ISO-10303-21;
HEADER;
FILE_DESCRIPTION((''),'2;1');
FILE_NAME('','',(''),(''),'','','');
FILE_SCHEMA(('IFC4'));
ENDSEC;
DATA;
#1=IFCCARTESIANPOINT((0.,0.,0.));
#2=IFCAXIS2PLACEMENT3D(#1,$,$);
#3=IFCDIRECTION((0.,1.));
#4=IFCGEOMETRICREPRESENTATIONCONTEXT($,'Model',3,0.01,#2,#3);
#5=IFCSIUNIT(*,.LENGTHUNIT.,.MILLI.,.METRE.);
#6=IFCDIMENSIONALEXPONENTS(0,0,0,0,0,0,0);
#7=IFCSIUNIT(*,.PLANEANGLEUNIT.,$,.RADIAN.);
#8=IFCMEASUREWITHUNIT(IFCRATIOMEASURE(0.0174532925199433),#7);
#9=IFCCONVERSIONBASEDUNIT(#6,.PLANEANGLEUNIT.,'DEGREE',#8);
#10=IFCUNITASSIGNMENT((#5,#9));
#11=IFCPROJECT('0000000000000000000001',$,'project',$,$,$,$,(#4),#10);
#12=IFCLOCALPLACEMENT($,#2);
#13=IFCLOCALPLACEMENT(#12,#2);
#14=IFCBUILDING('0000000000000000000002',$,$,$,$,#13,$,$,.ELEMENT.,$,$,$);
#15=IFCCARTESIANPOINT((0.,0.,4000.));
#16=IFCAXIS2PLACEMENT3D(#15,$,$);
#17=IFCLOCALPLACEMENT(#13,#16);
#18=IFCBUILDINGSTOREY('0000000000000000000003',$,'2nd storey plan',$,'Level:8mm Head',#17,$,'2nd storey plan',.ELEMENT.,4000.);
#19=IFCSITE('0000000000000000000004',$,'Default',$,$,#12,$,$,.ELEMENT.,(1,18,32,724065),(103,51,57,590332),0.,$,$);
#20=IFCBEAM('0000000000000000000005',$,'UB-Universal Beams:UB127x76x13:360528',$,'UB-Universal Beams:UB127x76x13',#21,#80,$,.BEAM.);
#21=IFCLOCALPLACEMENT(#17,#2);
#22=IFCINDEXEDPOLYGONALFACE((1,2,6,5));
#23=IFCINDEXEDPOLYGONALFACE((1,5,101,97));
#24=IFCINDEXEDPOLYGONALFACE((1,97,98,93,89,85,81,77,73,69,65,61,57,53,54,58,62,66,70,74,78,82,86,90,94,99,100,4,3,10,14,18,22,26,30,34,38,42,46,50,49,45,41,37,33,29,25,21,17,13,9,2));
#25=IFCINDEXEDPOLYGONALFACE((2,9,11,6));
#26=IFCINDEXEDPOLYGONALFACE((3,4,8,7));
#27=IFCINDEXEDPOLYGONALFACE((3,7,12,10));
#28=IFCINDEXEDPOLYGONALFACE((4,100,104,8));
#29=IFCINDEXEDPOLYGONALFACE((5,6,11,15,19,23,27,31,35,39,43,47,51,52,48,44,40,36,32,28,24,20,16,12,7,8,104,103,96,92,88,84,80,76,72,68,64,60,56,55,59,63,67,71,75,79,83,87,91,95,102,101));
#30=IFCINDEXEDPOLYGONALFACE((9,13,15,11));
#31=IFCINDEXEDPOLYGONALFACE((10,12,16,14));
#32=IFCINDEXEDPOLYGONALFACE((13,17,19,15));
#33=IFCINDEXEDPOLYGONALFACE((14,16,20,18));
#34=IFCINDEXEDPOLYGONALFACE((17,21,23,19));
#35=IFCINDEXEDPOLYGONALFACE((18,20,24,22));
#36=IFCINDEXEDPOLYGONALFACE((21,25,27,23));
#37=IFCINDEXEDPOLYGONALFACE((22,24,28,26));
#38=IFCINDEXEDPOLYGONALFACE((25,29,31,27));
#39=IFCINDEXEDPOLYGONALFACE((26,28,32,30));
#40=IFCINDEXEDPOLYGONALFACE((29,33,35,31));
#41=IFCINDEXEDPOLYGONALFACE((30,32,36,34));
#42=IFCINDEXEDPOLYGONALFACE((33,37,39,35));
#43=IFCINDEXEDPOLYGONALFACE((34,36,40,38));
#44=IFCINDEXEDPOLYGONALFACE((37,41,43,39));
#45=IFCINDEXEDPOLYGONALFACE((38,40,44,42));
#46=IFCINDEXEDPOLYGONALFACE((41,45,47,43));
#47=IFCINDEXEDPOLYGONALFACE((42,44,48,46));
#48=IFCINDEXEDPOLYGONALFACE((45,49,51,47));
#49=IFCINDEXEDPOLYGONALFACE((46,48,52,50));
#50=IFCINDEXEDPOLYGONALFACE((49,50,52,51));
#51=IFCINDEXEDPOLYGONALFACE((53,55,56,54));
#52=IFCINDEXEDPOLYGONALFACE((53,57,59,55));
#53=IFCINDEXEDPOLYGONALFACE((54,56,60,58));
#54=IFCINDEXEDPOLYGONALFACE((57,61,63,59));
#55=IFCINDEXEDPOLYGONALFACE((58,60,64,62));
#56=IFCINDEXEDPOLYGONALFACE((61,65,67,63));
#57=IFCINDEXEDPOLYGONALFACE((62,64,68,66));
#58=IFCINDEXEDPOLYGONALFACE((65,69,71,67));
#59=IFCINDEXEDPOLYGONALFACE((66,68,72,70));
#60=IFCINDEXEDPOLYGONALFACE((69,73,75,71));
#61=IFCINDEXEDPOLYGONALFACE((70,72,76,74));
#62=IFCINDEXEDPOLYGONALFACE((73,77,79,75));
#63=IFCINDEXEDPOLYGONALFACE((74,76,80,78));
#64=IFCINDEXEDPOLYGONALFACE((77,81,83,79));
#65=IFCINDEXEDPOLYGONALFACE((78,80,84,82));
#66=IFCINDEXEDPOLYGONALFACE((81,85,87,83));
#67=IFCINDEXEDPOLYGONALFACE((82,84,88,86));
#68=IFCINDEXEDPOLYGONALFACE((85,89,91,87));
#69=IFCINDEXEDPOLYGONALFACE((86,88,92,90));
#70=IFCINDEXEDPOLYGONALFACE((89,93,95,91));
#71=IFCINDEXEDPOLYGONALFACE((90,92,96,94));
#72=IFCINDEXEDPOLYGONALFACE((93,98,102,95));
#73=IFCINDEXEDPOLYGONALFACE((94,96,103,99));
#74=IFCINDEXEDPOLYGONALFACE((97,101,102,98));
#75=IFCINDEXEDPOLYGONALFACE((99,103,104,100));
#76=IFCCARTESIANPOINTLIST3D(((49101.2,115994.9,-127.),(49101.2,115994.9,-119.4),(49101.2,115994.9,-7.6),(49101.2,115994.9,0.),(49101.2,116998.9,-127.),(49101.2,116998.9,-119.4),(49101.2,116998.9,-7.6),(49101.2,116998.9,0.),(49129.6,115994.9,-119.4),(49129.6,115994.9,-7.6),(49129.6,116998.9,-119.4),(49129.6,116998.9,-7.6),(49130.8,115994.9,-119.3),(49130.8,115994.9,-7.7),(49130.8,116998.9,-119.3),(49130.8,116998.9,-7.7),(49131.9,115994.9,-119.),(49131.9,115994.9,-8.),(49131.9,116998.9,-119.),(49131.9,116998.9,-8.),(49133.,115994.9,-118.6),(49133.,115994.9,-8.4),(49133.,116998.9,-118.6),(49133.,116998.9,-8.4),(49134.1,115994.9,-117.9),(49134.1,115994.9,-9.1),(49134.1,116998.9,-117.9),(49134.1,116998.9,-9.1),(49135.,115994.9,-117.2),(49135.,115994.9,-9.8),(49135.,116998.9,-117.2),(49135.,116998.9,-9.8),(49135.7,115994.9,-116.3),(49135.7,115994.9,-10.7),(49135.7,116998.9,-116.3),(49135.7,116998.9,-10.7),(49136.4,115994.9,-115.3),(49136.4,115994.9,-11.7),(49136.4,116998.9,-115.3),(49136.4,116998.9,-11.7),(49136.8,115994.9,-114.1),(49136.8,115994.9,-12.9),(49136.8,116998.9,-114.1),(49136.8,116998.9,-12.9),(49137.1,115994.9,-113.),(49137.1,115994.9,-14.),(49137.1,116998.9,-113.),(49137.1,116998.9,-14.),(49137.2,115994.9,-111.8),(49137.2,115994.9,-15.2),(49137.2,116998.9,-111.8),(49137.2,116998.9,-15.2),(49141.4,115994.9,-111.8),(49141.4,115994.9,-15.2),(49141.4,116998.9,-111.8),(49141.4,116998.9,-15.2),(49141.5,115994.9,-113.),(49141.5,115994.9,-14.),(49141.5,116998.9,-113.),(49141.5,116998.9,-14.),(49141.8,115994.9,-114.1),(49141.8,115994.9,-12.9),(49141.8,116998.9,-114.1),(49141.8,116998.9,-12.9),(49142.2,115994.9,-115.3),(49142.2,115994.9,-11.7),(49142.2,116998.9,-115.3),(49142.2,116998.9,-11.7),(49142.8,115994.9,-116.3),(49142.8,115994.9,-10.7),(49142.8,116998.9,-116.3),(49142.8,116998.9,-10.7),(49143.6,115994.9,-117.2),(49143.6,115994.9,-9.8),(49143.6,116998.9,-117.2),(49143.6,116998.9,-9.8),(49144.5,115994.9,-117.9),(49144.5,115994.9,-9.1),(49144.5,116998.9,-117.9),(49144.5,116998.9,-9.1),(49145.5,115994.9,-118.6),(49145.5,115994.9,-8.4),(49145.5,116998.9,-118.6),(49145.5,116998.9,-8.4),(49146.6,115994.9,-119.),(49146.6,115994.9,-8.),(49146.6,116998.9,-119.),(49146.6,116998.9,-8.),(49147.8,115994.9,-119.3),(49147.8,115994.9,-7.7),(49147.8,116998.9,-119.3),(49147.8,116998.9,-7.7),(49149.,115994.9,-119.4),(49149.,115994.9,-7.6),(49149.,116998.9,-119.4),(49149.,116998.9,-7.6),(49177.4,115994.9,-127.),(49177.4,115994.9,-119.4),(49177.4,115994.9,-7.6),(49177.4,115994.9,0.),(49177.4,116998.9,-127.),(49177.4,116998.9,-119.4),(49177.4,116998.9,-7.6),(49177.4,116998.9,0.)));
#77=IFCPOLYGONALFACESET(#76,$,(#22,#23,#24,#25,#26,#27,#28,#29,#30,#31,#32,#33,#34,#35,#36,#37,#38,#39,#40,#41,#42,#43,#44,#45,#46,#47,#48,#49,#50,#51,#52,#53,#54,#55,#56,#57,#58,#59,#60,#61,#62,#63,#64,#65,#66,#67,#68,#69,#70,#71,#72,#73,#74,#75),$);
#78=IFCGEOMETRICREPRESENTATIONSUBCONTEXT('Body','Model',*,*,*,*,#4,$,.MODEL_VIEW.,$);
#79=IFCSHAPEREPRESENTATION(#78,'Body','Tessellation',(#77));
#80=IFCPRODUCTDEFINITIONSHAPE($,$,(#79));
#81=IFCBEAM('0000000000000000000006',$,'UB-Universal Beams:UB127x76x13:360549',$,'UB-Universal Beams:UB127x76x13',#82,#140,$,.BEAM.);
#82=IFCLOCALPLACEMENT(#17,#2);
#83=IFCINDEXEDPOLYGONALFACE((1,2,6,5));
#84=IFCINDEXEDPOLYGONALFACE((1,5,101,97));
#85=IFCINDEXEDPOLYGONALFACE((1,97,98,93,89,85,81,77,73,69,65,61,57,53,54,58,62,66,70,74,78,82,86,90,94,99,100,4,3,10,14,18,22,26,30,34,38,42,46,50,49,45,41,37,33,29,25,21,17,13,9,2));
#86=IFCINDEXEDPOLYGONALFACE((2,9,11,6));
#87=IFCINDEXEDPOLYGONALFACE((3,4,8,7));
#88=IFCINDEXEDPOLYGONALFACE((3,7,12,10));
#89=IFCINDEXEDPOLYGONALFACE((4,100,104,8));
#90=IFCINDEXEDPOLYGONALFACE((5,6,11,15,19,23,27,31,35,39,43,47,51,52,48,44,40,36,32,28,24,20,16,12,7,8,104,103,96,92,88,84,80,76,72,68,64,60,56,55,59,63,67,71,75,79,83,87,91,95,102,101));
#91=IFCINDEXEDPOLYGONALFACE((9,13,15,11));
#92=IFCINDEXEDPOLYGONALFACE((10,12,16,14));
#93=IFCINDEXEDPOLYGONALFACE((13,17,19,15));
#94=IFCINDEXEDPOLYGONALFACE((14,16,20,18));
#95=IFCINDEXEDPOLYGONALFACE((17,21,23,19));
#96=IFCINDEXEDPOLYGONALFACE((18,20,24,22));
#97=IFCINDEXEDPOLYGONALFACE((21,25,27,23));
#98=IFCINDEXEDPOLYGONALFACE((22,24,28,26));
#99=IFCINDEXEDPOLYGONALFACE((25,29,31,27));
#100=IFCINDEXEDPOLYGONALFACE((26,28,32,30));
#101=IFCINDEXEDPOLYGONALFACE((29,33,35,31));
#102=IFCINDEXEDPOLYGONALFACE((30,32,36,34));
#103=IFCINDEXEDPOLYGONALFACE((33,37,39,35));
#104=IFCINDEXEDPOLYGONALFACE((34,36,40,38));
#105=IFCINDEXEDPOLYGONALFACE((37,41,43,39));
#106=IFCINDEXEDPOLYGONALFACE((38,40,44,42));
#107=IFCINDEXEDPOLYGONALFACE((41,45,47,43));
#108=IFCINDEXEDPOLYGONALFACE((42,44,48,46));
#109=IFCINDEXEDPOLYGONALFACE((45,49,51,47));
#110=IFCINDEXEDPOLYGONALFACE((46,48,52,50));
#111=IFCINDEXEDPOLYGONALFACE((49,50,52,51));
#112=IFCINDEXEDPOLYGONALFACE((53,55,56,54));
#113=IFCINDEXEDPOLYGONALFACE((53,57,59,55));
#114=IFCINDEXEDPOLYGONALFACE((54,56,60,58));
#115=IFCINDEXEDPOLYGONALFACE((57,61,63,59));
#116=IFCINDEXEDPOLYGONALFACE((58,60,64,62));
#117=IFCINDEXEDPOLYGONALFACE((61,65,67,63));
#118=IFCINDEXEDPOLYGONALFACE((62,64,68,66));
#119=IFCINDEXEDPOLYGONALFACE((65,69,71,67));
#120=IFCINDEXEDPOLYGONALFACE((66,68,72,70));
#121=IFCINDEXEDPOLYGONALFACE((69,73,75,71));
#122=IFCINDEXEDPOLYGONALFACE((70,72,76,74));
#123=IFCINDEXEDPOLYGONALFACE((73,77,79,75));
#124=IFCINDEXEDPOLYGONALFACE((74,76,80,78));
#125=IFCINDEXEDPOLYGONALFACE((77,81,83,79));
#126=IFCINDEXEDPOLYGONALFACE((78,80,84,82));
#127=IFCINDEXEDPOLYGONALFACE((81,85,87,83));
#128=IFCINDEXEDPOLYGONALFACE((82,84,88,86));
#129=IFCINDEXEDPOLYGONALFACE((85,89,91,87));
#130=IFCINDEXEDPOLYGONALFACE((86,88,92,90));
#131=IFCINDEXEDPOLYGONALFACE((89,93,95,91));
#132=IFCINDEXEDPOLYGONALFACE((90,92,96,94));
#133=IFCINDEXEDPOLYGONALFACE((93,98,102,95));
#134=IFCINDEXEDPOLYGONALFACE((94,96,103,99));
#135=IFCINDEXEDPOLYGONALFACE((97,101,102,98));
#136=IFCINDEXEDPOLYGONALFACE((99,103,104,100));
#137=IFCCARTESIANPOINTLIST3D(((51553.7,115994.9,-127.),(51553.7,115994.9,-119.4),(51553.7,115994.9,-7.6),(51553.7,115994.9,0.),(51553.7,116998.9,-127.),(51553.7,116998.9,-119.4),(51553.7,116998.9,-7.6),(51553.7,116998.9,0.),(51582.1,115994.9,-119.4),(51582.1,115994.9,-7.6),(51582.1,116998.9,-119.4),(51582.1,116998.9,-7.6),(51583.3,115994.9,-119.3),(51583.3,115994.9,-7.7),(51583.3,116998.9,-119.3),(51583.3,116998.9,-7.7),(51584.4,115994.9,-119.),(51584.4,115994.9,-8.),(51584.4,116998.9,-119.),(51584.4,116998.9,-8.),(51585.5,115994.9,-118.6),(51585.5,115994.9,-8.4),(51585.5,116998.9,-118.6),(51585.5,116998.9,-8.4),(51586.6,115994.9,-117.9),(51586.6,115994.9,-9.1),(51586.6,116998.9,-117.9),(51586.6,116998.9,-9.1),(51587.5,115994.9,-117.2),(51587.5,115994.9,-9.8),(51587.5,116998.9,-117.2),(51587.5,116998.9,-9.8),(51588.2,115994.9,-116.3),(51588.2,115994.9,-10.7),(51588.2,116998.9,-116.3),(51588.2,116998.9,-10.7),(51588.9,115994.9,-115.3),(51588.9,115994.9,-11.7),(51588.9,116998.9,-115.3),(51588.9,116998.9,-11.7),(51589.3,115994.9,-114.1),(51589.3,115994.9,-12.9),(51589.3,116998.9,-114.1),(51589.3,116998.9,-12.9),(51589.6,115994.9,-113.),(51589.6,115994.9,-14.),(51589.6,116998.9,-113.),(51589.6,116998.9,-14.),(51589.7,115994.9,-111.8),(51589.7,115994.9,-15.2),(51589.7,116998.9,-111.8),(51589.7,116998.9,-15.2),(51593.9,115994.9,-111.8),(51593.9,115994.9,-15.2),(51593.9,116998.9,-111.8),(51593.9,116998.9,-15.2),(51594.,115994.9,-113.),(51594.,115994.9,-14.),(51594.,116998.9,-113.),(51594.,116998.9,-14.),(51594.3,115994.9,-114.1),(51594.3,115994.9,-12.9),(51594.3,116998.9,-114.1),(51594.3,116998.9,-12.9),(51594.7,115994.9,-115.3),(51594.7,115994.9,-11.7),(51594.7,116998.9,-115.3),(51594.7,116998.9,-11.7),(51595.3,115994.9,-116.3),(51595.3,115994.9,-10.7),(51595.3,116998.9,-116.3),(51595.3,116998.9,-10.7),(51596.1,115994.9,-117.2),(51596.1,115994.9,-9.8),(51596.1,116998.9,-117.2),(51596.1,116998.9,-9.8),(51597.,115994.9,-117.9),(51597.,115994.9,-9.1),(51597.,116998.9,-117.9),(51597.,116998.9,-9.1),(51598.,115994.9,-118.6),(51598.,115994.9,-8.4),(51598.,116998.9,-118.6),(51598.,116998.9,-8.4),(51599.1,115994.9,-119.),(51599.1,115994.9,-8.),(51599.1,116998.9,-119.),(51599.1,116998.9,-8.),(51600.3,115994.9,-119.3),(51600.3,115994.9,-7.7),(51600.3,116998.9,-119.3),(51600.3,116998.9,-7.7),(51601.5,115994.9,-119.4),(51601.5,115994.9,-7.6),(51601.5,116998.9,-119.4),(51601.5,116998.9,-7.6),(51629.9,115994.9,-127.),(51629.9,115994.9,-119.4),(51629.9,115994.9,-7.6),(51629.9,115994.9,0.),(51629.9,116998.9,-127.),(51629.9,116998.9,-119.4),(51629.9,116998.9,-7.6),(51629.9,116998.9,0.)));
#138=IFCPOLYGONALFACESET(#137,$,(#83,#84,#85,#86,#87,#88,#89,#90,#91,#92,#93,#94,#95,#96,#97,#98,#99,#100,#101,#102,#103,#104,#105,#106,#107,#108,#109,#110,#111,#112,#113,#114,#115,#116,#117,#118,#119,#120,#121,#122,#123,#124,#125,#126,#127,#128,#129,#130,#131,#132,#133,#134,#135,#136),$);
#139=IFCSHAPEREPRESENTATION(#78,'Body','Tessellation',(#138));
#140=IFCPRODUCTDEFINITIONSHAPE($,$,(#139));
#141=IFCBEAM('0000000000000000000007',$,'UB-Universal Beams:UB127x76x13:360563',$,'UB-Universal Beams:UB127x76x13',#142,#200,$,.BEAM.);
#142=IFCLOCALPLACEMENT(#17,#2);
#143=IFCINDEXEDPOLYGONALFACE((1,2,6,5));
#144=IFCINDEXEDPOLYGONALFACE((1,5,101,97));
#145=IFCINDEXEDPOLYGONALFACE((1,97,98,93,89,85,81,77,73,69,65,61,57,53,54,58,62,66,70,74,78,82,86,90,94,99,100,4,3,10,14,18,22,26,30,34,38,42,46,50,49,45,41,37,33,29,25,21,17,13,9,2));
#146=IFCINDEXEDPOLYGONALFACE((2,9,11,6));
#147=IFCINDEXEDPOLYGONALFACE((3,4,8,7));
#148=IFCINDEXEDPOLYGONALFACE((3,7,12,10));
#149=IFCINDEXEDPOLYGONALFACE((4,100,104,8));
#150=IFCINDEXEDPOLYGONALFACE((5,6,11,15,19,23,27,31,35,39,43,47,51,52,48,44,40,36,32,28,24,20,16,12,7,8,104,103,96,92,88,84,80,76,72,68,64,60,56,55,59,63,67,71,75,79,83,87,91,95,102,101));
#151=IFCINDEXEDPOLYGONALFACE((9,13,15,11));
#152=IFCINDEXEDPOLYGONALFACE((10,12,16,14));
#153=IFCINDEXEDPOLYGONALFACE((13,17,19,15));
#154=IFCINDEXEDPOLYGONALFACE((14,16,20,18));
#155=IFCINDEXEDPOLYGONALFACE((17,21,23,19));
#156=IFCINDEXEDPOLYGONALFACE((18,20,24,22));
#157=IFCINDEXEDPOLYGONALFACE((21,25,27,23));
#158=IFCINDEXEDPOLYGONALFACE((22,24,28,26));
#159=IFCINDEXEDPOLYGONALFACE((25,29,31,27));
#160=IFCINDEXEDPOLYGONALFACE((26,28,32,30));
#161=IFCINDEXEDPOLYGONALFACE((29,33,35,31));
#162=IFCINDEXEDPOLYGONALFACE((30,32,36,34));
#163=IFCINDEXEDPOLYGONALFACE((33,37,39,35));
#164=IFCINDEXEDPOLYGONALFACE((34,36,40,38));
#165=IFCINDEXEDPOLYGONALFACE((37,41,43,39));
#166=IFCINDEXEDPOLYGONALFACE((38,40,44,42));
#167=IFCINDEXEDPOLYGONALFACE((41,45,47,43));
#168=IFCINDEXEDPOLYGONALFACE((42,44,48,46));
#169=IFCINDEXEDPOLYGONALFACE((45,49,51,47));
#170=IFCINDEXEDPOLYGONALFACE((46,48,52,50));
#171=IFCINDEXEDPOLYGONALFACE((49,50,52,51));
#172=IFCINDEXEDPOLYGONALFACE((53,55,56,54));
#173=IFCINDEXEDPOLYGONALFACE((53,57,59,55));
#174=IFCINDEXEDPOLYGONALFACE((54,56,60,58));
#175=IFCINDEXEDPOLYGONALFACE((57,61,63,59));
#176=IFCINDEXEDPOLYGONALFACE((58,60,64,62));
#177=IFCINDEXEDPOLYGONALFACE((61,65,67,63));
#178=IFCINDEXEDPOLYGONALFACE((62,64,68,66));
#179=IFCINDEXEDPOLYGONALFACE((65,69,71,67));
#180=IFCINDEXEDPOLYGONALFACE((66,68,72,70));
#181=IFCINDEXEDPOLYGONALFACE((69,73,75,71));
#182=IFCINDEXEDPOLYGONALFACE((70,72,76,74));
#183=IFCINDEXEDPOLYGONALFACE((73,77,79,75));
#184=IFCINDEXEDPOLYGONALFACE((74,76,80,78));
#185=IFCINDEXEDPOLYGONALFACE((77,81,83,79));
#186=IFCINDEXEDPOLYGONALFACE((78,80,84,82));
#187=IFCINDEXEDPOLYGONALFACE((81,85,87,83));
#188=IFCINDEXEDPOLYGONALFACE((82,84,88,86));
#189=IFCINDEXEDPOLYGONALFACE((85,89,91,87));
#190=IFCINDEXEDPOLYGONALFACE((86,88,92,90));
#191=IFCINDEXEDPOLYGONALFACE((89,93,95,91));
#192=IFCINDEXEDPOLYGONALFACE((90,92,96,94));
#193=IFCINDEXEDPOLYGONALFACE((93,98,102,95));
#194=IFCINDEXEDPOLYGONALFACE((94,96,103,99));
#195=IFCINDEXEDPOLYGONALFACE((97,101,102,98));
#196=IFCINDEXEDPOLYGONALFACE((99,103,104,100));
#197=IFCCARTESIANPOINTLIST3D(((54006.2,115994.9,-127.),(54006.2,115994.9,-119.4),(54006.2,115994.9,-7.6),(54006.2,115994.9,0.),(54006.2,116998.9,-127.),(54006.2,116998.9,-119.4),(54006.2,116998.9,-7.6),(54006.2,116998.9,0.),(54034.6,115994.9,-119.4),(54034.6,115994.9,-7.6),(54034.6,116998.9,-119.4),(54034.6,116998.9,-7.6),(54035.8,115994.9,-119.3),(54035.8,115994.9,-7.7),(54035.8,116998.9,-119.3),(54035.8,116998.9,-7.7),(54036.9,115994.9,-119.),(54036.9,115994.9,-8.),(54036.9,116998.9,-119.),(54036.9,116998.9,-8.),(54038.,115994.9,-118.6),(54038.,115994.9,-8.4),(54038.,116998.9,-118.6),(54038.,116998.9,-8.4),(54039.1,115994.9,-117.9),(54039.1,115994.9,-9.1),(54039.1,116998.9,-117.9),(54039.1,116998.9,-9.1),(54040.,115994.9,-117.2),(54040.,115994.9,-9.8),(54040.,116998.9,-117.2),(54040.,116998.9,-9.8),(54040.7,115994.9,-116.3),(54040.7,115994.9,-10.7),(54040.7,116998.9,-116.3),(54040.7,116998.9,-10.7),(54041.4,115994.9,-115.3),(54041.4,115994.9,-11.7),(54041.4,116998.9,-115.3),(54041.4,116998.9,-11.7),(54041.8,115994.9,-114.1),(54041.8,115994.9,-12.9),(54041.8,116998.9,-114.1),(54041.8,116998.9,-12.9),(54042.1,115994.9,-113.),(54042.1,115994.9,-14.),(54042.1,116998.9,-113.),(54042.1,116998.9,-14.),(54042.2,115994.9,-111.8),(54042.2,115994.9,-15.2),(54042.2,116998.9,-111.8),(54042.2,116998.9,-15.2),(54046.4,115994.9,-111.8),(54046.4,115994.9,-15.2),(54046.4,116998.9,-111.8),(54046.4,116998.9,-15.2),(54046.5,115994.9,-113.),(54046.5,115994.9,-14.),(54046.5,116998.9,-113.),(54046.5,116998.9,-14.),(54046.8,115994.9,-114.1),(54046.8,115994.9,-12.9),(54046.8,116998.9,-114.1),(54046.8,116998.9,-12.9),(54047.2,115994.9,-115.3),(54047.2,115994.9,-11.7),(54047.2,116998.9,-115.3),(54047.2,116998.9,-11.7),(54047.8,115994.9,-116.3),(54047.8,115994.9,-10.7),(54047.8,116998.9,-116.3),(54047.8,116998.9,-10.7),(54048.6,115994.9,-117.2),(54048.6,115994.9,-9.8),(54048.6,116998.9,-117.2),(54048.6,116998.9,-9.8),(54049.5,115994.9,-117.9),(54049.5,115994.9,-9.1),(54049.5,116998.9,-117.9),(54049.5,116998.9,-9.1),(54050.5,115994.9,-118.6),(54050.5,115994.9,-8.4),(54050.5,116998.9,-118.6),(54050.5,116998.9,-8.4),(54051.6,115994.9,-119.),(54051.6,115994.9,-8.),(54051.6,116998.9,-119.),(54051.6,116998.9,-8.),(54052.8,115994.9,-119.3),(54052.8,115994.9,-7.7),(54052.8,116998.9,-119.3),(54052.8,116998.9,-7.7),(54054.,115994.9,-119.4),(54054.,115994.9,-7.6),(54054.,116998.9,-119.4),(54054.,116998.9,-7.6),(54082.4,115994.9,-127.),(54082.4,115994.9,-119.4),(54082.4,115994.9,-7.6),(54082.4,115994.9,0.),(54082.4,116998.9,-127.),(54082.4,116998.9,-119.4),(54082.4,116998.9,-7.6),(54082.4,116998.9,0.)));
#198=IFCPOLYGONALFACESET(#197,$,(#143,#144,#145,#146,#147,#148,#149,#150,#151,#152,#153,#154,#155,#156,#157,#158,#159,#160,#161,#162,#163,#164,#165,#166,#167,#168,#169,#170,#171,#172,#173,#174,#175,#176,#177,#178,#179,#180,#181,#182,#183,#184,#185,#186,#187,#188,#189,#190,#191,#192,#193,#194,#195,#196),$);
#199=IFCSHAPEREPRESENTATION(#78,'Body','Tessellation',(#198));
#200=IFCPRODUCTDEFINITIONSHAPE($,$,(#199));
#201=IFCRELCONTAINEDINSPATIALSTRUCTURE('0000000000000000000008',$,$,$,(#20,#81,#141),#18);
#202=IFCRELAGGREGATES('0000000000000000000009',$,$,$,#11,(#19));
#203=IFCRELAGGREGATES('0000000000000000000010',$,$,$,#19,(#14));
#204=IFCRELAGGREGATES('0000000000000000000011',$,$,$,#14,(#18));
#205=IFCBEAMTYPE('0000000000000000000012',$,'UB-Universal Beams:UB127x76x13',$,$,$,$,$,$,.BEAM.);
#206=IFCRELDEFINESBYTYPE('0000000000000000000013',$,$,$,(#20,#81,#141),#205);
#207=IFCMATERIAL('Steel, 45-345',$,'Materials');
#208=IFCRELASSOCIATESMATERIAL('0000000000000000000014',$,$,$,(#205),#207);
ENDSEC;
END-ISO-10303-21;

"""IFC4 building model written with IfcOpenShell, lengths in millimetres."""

from ifc_helpers import new_model, entity, si_unit, converted_unit, direction, frame, origin, place, context, subcontext, project, spatial, indexed_curve, outline, extrude, source, transform, mapped, material, type_object, type_shapes, element, save


model = new_model("IFC4")

# Units and contexts
model_context = context("Model", 3, precision=0.01, world=origin(), true_north=direction((0.0, 1.0)))
body_context = subcontext(model_context, "Body", "Model", "MODEL_VIEW")
ifc_project = project(units=[si_unit("LENGTHUNIT", "METRE", prefix="MILLI"), converted_unit("PLANEANGLEUNIT", "DEGREE", entity("IfcRatioMeasure", 0.0174532925199433), si_unit("PLANEANGLEUNIT", "RADIAN"), dimensions=[0, 0, 0, 0, 0, 0, 0])], contexts=[model_context])

# Site, building, storey
site_placement = place(None, origin())
site = spatial("IfcSite", under=ifc_project, at=site_placement, Name="Default", CompositionType="ELEMENT", RefLatitude=(1, 18, 32, 724065), RefLongitude=(103, 51, 57, 590332), RefElevation=0.0)
building_placement = place(site_placement, origin())
building = spatial("IfcBuilding", under=site, at=building_placement, CompositionType="ELEMENT")
storey_placement = place(building_placement, frame((0.0, 0.0, 4000.0)))
storey = spatial("IfcBuildingStorey", under=building, at=storey_placement, Name="2nd storey plan", ObjectType="Level:8mm Head", LongName="2nd storey plan", CompositionType="ELEMENT", Elevation=4000.0)

# Beams
ifc_material_1 = material(Name="Steel, 45-345", Category="Materials")
beam_type_1 = type_object("IfcBeamType", Name="UB-Universal Beams:UB127x76x13", PredefinedType="BEAM", material=ifc_material_1)
shared_shape_1 = source(origin(), body_context, "Body", "SweptSolid", [
    extrude(outline(indexed_curve([(-63.5, -38.1), (-55.9, -38.1), (-55.9, -9.7), (-55.8, -8.5), (-55.5, -7.4), (-55.1, -6.2), (-54.4, -5.2), (-53.7, -4.3), (-52.8, -3.6), (-51.8, -2.9), (-50.6, -2.5), (-49.5, -2.2), (-48.3, -2.1), (48.3, -2.1), (49.5, -2.2), (50.6, -2.5), (51.8, -2.9), (52.8, -3.6), (53.7, -4.3), (54.4, -5.2), (55.1, -6.2), (55.5, -7.4), (55.8, -8.5), (55.9, -9.7), (55.9, -38.1), (63.5, -38.1), (63.5, 38.1), (55.9, 38.1), (55.9, 9.7), (55.8, 8.5), (55.5, 7.4), (55.1, 6.2), (54.4, 5.2), (53.7, 4.3), (52.8, 3.6), (51.8, 2.9), (50.6, 2.5), (49.5, 2.2), (48.3, 2.1), (-48.3, 2.1), (-49.5, 2.2), (-50.6, 2.5), (-51.8, 2.9), (-52.8, 3.6), (-53.7, 4.3), (-54.4, 5.2), (-55.1, 6.2), (-55.5, 7.4), (-55.8, 8.5), (-55.9, 9.7), (-55.9, 38.1), (-63.5, 38.1), (-63.5, -38.1)], self_intersect=False)), frame((-335.5, 0.0, 0.0), z_axis=(1.0, 0.0, 0.0), x_axis=(0.0, 0.0, -1.0)), (0.0, 0.0, 1.0), 1004.0),
])
type_shapes(beam_type_1, [shared_shape_1])
for number, where, z_axis, x_axis, name in (
    (1, (49139.3, 116330.4, -63.5), (0.0, 0.0, 1.0), (0.0, 1.0, 0.0), "UB-Universal Beams:UB127x76x13:360528"),
    (2, (51591.8, 116330.4, -63.5), (0.0, 0.0, 1.0), (0.0, 1.0, 0.0), "UB-Universal Beams:UB127x76x13:360549"),
    (3, (54044.3, 116330.4, -63.5), (0.0, 0.0, 1.0), (0.0, 1.0, 0.0), "UB-Universal Beams:UB127x76x13:360563"),
):
    element("IfcBeam", number, at=place(storey_placement, frame(where, z_axis=z_axis, x_axis=x_axis)), inside=storey, type_object=beam_type_1, Name=name, ObjectType="UB-Universal Beams:UB127x76x13", PredefinedType="BEAM", context=body_context, shape_type="MappedRepresentation", body=[
        mapped(shared_shape_1, transform((0.0, 0.0, 0.0), scale=1.0)),
    ])

save(model, "model.ifc")
